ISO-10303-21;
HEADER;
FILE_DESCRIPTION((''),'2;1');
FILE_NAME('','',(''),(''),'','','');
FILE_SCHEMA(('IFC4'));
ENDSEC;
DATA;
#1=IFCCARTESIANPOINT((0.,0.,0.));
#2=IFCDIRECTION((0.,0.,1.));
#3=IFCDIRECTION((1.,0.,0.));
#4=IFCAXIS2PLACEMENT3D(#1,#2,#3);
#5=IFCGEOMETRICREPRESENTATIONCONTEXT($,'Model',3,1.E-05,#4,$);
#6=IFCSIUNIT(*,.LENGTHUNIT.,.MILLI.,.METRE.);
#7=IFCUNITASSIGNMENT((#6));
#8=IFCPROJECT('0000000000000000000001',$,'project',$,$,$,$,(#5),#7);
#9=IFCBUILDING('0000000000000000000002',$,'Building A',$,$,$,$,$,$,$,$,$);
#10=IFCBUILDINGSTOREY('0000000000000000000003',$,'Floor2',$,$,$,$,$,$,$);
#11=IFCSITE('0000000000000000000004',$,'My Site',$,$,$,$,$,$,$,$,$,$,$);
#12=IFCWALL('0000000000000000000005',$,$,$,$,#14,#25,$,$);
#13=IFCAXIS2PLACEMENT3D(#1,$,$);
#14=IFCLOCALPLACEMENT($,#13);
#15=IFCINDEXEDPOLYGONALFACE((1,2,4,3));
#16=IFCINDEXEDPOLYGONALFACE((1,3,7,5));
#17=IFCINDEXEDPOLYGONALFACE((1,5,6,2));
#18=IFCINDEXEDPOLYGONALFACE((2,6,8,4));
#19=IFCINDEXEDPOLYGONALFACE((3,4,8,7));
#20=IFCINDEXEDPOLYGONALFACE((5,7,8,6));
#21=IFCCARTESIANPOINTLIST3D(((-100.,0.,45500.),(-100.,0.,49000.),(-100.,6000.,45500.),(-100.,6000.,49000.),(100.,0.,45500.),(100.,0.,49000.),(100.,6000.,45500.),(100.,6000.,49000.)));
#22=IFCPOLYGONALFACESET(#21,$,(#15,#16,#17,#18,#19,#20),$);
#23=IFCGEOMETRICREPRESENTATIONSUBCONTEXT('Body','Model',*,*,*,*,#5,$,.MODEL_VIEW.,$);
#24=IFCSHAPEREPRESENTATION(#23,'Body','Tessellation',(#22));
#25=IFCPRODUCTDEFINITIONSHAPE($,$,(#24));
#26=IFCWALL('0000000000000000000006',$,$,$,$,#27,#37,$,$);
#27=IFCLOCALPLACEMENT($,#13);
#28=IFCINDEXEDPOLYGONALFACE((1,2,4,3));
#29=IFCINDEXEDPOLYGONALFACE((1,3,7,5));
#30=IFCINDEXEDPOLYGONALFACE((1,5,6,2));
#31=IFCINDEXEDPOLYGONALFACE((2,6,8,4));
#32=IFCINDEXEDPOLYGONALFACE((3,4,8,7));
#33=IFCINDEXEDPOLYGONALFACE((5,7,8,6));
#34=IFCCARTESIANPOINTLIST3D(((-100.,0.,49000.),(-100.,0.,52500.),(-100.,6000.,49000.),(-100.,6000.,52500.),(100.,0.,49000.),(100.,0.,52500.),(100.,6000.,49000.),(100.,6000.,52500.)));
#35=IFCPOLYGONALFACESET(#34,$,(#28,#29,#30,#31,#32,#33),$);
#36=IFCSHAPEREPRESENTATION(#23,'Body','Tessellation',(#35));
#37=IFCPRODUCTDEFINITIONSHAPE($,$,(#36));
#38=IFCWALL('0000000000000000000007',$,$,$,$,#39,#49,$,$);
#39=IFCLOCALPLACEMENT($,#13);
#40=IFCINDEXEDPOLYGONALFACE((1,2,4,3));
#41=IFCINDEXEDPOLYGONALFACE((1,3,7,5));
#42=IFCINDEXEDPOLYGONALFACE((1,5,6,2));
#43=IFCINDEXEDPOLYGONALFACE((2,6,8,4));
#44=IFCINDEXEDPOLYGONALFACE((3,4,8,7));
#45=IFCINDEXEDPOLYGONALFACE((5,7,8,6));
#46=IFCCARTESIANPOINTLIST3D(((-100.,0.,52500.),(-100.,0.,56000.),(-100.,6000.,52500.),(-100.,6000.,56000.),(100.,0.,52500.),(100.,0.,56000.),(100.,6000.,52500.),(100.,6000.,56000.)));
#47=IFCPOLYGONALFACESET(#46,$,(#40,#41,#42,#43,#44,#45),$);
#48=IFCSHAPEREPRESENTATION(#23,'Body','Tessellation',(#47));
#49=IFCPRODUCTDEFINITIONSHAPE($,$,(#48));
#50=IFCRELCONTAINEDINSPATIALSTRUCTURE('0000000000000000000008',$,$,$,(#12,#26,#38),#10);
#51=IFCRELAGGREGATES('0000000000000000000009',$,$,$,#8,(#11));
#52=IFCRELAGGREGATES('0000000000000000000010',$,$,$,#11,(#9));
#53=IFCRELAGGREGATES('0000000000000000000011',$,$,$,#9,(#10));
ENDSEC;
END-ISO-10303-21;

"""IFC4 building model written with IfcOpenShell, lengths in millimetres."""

from ifc_helpers import new_model, si_unit, frame, origin_with_axes, place, context, subcontext, project, spatial, indexed_curve, outline, extrude, element, save


model = new_model("IFC4")

# Units and contexts
model_context = context("Model", 3, precision=1e-05, world=origin_with_axes())
body_context = subcontext(model_context, "Body", "Model", "MODEL_VIEW")
ifc_project = project(units=[si_unit("LENGTHUNIT", "METRE", prefix="MILLI")], contexts=[model_context])

# Site, building, storey
site = spatial("IfcSite", under=ifc_project, Name="My Site")
building = spatial("IfcBuilding", under=site, Name="Building A")
storey = spatial("IfcBuildingStorey", under=building, Name="Floor2")

# Walls
for number, where, z_axis, x_axis in (
    (1, (-100.0, 6000.0, 45500.0), (0.0, 0.0, 1.0), (0.0, -1.0, 0.0)),
    (2, (-100.0, 6000.0, 49000.0), (0.0, 0.0, 1.0), (0.0, -1.0, 0.0)),
    (3, (-100.0, 6000.0, 52500.0), (0.0, 0.0, 1.0), (0.0, -1.0, 0.0)),
):
    element("IfcWall", number, at=place(None, frame(where, z_axis=z_axis, x_axis=x_axis)), inside=storey, context=body_context, shape_type="SweptSolid", body=[
        extrude(outline(indexed_curve([(0.0, 0.0), (0.0, 200.0), (6000.0, 200.0), (6000.0, 0.0), (0.0, 0.0)], self_intersect=False)), origin_with_axes(), (0.0, 0.0, 1.0), 3500.0),
    ])

save(model, "model.ifc")
